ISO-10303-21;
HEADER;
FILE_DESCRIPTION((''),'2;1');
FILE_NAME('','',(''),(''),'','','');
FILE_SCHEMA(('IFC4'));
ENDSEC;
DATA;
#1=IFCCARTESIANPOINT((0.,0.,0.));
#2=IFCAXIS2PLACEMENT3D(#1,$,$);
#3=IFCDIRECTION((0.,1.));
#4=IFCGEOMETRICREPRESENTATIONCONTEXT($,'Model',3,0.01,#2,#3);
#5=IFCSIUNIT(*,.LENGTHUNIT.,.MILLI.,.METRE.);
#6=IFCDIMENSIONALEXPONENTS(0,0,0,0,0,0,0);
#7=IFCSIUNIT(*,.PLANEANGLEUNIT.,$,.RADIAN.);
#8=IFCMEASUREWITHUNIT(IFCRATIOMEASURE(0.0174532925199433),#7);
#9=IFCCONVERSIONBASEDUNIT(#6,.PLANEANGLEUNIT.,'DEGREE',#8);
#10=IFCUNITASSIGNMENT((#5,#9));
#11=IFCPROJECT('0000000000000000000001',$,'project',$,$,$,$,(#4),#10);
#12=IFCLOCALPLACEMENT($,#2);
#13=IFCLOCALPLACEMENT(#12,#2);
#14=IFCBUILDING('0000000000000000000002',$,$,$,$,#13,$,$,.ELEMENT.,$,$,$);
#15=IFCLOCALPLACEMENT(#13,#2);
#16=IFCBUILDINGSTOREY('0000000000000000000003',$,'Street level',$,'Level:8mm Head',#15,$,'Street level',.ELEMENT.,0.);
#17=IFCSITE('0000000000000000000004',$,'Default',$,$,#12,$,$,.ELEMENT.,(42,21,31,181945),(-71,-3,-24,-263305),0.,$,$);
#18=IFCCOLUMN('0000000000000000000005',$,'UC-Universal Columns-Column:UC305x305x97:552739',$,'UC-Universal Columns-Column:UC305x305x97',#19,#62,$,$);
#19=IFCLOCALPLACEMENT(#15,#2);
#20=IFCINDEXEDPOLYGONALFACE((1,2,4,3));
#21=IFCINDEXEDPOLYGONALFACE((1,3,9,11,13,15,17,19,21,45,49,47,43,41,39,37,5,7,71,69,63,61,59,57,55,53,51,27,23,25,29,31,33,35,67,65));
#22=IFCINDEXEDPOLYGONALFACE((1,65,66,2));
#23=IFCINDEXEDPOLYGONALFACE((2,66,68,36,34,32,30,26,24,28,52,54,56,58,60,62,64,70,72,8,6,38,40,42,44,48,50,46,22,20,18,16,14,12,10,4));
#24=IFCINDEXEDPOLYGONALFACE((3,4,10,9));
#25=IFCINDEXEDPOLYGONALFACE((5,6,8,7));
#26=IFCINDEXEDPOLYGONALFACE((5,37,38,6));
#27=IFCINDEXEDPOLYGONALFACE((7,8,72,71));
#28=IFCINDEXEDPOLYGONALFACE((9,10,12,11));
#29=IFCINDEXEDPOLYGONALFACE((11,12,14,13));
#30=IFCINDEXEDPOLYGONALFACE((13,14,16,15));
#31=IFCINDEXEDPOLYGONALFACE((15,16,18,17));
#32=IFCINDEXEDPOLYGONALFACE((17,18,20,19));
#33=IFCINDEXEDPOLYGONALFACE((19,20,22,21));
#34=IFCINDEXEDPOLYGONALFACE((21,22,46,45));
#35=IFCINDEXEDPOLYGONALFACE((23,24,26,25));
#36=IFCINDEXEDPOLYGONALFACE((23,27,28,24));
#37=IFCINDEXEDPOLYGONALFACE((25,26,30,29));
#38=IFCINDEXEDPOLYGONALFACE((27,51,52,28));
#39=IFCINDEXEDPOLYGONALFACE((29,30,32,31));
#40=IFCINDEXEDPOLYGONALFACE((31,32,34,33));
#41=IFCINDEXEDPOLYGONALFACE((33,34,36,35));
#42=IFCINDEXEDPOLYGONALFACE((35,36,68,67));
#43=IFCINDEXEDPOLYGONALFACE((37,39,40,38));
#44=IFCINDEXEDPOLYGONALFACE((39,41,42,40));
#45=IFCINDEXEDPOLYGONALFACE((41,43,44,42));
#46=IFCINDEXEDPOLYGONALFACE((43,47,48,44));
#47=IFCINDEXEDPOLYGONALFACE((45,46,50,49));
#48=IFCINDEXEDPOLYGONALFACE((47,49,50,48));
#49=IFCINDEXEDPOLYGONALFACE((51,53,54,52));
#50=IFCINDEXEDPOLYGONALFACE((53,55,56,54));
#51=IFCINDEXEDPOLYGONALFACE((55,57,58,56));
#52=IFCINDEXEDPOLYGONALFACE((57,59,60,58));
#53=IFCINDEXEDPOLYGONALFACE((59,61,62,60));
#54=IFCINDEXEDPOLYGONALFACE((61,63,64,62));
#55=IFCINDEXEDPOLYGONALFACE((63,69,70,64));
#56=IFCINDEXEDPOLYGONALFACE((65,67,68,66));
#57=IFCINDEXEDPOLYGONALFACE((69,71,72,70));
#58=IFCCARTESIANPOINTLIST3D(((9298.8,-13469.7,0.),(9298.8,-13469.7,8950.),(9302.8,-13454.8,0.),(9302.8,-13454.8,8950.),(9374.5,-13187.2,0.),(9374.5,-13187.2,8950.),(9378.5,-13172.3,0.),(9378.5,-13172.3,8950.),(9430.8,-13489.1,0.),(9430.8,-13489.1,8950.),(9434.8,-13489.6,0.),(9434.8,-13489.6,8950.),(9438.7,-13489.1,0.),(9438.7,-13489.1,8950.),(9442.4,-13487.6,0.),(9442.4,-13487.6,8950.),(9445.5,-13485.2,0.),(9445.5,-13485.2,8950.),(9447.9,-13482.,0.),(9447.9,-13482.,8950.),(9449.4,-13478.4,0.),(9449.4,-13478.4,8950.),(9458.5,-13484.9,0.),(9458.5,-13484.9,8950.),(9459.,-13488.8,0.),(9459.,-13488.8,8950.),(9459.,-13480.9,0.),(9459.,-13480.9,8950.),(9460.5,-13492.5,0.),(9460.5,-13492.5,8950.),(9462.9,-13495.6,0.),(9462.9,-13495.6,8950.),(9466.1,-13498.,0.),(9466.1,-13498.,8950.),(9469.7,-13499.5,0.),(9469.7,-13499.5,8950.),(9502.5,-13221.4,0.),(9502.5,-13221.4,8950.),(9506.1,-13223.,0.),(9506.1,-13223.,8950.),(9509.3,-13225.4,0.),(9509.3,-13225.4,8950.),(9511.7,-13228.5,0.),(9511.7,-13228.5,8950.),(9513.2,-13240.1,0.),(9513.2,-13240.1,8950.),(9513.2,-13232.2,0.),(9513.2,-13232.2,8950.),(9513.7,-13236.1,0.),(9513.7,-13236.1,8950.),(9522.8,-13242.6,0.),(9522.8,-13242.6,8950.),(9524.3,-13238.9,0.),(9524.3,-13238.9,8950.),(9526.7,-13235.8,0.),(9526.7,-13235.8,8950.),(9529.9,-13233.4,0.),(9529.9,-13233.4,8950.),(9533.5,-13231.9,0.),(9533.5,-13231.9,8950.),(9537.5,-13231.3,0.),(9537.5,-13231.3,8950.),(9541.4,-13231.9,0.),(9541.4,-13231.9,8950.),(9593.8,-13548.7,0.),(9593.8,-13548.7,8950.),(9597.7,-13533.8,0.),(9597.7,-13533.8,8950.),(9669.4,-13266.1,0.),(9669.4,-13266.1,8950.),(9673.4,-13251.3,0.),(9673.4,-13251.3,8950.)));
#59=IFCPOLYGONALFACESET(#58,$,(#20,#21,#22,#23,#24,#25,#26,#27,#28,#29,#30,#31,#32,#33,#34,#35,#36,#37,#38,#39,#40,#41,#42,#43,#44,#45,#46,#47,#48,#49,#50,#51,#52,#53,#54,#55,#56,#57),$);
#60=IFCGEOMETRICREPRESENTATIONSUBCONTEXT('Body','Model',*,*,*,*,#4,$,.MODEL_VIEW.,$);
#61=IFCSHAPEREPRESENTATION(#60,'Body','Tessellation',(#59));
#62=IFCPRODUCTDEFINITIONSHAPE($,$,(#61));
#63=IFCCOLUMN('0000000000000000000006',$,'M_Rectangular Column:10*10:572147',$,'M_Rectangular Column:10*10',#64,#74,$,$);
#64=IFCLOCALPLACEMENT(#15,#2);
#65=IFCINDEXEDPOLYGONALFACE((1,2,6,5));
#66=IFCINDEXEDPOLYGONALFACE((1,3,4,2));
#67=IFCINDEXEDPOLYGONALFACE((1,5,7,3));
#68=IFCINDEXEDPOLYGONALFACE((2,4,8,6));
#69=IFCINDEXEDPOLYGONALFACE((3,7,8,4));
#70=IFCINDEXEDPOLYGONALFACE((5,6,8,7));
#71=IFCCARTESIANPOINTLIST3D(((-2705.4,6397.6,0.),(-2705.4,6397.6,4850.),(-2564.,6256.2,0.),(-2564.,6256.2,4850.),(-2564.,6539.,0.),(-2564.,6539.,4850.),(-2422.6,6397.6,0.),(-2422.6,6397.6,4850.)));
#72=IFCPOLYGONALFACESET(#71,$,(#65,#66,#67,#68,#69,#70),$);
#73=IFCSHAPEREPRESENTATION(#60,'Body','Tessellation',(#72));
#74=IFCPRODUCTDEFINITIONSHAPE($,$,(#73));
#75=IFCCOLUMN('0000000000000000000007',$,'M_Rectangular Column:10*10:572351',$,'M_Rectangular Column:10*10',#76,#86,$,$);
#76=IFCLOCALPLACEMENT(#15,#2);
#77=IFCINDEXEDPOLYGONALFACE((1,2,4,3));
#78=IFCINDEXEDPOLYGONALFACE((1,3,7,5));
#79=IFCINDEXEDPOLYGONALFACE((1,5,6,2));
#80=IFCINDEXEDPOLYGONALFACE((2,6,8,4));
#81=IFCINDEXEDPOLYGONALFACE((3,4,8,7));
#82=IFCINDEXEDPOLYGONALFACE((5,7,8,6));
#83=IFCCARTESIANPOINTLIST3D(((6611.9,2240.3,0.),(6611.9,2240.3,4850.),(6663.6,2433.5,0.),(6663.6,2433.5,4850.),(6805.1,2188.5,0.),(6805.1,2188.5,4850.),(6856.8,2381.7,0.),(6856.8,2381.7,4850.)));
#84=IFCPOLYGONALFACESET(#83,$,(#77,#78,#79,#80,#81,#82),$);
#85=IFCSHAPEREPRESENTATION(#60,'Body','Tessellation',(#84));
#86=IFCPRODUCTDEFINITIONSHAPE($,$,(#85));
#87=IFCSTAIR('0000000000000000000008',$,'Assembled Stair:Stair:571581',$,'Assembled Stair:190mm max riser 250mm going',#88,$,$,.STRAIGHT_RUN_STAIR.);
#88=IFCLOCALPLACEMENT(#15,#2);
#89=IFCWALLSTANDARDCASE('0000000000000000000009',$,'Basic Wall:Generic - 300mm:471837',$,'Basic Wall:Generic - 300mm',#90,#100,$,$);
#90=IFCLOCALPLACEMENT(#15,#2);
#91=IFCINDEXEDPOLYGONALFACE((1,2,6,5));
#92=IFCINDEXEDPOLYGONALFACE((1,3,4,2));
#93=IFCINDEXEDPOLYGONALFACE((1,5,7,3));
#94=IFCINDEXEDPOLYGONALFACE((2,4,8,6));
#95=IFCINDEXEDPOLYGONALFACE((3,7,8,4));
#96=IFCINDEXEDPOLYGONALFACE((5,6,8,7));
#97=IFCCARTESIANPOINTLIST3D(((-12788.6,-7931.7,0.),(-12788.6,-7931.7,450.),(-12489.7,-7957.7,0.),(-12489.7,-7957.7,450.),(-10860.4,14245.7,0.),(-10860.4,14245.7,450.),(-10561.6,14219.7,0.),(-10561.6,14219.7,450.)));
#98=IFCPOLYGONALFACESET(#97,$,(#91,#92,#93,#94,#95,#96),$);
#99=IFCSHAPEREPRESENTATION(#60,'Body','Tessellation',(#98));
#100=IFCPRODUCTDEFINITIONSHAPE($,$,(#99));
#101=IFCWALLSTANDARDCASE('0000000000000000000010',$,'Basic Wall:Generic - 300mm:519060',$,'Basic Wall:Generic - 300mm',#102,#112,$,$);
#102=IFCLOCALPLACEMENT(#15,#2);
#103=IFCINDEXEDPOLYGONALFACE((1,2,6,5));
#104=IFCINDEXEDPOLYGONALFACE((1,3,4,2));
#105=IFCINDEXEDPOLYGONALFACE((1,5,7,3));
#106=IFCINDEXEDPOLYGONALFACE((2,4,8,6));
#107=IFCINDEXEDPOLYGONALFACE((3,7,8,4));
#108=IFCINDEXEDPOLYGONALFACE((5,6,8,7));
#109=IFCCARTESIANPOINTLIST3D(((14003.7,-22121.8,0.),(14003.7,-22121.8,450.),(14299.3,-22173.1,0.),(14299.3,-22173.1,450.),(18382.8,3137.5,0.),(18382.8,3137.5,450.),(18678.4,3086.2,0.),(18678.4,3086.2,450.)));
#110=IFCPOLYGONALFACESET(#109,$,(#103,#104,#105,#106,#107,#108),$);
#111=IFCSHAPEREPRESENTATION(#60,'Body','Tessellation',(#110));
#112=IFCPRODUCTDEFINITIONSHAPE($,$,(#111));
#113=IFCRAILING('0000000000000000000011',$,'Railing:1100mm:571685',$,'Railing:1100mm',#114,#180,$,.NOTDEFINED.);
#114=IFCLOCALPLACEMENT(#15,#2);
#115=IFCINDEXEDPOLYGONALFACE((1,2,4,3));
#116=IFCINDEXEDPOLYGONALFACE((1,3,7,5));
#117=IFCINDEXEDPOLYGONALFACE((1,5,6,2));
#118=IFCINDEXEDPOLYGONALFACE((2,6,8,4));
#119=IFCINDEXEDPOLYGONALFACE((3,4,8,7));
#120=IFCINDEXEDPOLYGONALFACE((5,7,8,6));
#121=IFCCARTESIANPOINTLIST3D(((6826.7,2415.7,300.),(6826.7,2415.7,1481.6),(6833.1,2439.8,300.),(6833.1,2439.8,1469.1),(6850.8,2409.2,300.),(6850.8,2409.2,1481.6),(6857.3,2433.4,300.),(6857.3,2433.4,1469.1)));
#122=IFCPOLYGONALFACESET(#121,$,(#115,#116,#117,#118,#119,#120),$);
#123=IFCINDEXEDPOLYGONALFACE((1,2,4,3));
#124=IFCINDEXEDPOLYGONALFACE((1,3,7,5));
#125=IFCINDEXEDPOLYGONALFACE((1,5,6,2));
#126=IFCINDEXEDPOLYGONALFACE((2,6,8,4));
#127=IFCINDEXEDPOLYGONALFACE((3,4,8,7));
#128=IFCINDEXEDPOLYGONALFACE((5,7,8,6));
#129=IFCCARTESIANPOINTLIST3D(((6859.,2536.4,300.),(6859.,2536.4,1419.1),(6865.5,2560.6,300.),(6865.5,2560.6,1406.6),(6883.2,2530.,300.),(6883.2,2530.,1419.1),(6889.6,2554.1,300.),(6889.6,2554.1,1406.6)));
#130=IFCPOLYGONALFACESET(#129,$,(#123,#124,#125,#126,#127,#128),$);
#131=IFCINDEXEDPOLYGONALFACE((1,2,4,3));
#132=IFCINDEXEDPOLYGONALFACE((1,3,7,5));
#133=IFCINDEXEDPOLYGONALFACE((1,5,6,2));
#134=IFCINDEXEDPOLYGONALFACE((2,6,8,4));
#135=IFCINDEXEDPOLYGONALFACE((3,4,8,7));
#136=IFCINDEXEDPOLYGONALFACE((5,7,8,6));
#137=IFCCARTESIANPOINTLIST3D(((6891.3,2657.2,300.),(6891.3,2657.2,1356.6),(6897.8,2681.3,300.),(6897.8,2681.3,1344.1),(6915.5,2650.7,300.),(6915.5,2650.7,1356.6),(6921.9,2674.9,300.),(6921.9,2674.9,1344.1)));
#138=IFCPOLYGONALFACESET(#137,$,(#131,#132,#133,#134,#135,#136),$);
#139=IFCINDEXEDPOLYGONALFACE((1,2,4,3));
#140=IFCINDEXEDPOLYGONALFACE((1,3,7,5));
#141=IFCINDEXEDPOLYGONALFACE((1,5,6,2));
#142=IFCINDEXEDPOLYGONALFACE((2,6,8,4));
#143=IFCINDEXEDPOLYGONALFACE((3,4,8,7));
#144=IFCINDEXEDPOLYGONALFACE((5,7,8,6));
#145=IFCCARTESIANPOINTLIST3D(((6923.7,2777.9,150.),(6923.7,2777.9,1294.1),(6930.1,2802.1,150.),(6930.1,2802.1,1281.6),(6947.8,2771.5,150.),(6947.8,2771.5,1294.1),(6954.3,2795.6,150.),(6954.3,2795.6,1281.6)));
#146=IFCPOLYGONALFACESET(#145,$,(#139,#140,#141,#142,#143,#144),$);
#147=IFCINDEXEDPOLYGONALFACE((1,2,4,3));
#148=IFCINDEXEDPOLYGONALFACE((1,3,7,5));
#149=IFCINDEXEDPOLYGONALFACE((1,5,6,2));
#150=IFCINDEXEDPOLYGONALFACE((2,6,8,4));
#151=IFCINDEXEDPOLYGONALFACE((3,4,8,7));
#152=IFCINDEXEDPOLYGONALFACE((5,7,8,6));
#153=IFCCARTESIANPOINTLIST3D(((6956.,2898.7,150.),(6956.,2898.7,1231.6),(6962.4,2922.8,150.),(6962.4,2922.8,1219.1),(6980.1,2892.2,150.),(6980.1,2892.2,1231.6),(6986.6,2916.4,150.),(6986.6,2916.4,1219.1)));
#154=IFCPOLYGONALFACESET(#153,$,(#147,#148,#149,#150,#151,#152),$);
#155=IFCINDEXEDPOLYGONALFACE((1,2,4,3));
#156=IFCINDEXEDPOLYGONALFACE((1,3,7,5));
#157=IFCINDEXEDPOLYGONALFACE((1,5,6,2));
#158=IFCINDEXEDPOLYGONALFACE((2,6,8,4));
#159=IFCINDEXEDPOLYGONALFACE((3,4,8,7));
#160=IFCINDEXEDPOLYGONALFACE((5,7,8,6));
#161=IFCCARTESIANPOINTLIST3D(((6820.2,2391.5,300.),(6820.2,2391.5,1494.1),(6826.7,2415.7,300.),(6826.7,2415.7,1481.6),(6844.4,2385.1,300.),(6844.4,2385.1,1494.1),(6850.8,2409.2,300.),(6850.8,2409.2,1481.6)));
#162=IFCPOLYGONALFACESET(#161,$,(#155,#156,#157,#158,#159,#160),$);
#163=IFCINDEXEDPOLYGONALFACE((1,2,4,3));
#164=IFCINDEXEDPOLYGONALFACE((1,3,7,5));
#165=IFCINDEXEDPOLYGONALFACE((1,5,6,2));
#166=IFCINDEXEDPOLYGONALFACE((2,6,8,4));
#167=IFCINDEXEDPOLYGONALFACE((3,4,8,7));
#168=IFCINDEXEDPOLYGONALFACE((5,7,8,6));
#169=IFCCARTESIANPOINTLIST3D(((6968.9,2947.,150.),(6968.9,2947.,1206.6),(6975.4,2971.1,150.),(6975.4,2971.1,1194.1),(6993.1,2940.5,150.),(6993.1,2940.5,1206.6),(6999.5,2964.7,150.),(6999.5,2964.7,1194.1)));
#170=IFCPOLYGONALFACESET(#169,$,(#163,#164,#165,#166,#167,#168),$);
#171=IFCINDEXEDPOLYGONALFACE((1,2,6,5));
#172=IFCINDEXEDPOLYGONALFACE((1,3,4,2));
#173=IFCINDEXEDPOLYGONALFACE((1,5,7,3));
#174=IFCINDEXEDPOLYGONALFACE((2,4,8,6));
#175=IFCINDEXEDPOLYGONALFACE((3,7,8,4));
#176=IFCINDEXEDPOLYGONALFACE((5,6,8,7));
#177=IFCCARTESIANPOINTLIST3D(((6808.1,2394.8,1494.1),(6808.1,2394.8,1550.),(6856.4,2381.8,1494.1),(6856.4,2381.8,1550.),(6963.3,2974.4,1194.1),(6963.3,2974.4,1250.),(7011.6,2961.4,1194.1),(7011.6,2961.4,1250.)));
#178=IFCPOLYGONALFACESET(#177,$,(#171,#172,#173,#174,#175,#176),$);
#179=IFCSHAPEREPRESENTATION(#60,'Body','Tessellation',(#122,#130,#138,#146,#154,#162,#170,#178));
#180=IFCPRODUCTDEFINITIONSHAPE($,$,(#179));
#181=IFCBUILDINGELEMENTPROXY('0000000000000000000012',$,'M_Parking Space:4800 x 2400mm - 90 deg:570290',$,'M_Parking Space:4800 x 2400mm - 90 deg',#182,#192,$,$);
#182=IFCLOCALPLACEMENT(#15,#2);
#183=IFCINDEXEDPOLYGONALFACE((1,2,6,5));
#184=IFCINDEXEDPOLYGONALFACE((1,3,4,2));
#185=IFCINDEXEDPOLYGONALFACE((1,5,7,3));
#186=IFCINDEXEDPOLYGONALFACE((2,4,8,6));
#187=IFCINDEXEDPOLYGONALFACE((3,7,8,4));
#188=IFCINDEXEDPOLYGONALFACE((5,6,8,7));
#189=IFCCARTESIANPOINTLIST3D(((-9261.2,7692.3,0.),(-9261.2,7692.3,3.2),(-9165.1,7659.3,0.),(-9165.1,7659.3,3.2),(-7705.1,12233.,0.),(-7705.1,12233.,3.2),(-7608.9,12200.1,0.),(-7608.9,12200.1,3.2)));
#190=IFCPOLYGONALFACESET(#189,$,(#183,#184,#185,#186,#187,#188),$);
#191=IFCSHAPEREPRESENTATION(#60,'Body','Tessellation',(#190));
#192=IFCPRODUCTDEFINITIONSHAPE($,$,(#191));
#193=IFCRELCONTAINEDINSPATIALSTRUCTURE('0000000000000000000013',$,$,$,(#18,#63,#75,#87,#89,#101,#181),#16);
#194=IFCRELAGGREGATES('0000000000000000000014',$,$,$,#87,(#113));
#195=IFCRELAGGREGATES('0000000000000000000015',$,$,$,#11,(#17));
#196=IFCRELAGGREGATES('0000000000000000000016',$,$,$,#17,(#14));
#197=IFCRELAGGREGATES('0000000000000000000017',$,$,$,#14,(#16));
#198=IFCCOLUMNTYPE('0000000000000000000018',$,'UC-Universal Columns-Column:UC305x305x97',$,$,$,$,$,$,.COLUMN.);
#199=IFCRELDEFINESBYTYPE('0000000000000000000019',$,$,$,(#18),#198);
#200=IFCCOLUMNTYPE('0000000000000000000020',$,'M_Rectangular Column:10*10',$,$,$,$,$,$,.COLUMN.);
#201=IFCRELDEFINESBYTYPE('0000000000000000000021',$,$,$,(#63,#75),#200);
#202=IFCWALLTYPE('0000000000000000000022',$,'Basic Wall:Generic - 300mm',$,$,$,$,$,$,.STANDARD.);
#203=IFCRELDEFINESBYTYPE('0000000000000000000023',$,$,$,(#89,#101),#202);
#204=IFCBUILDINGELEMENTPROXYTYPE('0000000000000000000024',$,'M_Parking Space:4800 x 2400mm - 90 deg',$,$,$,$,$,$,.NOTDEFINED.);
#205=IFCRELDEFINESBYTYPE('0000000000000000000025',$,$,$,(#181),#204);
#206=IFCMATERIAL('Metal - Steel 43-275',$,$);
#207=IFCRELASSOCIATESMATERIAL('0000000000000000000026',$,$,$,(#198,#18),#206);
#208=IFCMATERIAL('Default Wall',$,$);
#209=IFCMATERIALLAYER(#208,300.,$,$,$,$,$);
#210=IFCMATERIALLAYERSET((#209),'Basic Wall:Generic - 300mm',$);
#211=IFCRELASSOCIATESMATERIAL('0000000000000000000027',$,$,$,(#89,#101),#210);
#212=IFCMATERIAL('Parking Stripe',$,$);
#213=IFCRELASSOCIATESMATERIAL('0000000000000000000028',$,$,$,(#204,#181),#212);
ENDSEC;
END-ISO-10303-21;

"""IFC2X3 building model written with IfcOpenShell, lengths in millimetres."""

from ifc_helpers import new_model, entity, si_unit, converted_unit, direction, frame, frame_2d, origin, origin_2d_with_axis, place, context, subcontext, project, spatial, polyline, rectangle, i_section, outline, extrude, source, transform, mapped, material, layer, layer_set, layer_usage, type_object, type_shapes, element, aggregate, save


model = new_model("IFC2X3")

# Units and contexts
model_context = context("Model", 3, precision=0.01, world=origin(), true_north=direction((0.0, 1.0)))
body_context = subcontext(model_context, "Body", "Model", "MODEL_VIEW")
ifc_project = project(units=[si_unit("LENGTHUNIT", "METRE", prefix="MILLI"), converted_unit("PLANEANGLEUNIT", "DEGREE", entity("IfcRatioMeasure", 0.0174532925199433), si_unit("PLANEANGLEUNIT", "RADIAN"), dimensions=[0, 0, 0, 0, 0, 0, 0])], contexts=[model_context])

# Site, building, storey
site_placement = place(None, origin())
site = spatial("IfcSite", under=ifc_project, at=site_placement, Name="Default", CompositionType="ELEMENT", RefLatitude=(42, 21, 31, 181945), RefLongitude=(-71, -3, -24, -263305), RefElevation=0.0)
building_placement = place(site_placement, origin())
building = spatial("IfcBuilding", under=site, at=building_placement, CompositionType="ELEMENT")
storey_placement = place(building_placement, origin())
storey = spatial("IfcBuildingStorey", under=building, at=storey_placement, Name="Street level", ObjectType="Level:8mm Head", LongName="Street level", CompositionType="ELEMENT", Elevation=0.0)

# Columns
ifc_material_1 = material(Name="Metal - Steel 43-275")
column_type_1 = type_object("IfcColumnType", Name="UC-Universal Columns-Column:UC305x305x97", PredefinedType="COLUMN", material=ifc_material_1)
shared_shape_1 = source(origin(), body_context, "Body", "SweptSolid", [
    extrude(i_section(OverallWidth=305.3, OverallDepth=307.9, WebThickness=9.9, FlangeThickness=15.4, FilletRadius=15.2, at=frame_2d((0.0, 0.0), x_axis=(0.0, 1.0))), frame((0.0, 0.0, 0.0), z_axis=(0.0, 0.0, 1.0), x_axis=(0.0, -1.0, 0.0)), (0.0, 0.0, 1.0), 8950.0),
])
type_shapes(column_type_1, [shared_shape_1])
column_placement = place(storey_placement, frame((9486.1, -13360.5, 0.0), z_axis=(0.0, 0.0, 1.0), x_axis=(0.965983, -0.258607, 0.0)))
element("IfcColumn", 1, at=column_placement, inside=storey, type_object=column_type_1, material=ifc_material_1, Name="UC-Universal Columns-Column:UC305x305x97:552739", ObjectType="UC-Universal Columns-Column:UC305x305x97", context=body_context, shape_type="MappedRepresentation", body=[
    mapped(shared_shape_1, transform((0.0, 0.0, 0.0), scale=1.0)),
])
column_type_2 = type_object("IfcColumnType", Name="M_Rectangular Column:10*10", PredefinedType="COLUMN")
shared_shape_2 = source(origin(), body_context, "Body", "SweptSolid", [
    extrude(rectangle(XDim=200.0, YDim=200.0, at=origin_2d_with_axis()), frame((0.0, 0.0, 0.0), z_axis=(0.0, 0.0, 1.0), x_axis=(0.0, -1.0, 0.0)), (0.0, 0.0, 1.0), 4850.0),
])
type_shapes(column_type_2, [shared_shape_2])
for number, where, z_axis, x_axis, name in (
    (2, (-2564.0, 6397.6, 0.0), (0.0, 0.0, 1.0), (0.707107, 0.707107, 0.0), "M_Rectangular Column:10*10:572147"),
    (3, (6734.4, 2311.0, 0.0), (0.0, 0.0, 1.0), (0.258607, 0.965983, 0.0), "M_Rectangular Column:10*10:572351"),
):
    element("IfcColumn", number, at=place(storey_placement, frame(where, z_axis=z_axis, x_axis=x_axis)), inside=storey, type_object=column_type_2, Name=name, ObjectType="M_Rectangular Column:10*10", context=body_context, shape_type="MappedRepresentation", body=[
        mapped(shared_shape_2, transform((0.0, 0.0, 0.0), scale=1.0)),
    ])

# Stair
stair_placement = place(storey_placement, origin())
stair = element("IfcStair", 4, at=stair_placement, inside=storey, Name="Assembled Stair:Stair:571581", ObjectType="Assembled Stair:190mm max riser 250mm going", ShapeType="STRAIGHT_RUN_STAIR")

# Walls
ifc_material_2 = material(Name="Default Wall")
ifc_layer_1 = layer(ifc_material_2, 300.0)
ifc_layer_set_1 = layer_set([ifc_layer_1], Name="Basic Wall:Generic - 300mm")
ifc_layer_usage_1 = layer_usage(ifc_layer_set_1, "AXIS2", "NEGATIVE", 150.0)
wall_type = type_object("IfcWallType", Name="Basic Wall:Generic - 300mm", PredefinedType="STANDARD")
wall_1_placement = place(storey_placement, frame((-10711.0, 14232.7, 0.0), z_axis=(0.0, 0.0, 1.0), x_axis=(-0.086615, -0.996242, 0.0)))
element("IfcWallStandardCase", 5, at=wall_1_placement, inside=storey, type_object=wall_type, material=ifc_layer_usage_1, Name="Basic Wall:Generic - 300mm:471837", ObjectType="Basic Wall:Generic - 300mm", context=body_context, shape_type="SweptSolid", body=[
    extrude(rectangle(XDim=22261.1, YDim=300.0, at=frame_2d((11130.5, 0.0), x_axis=(-1.0, 0.0))), origin(), (0.0, 0.0, 1.0), 450.0),
])
ifc_layer_usage_2 = layer_usage(ifc_layer_set_1, "AXIS2", "NEGATIVE", 150.0)
wall_2_placement = place(storey_placement, frame((14151.5, -22147.4, 0.0), z_axis=(0.0, 0.0, 1.0), x_axis=(0.17082, 0.985302, 0.0)))
element("IfcWallStandardCase", 6, at=wall_2_placement, inside=storey, type_object=wall_type, material=ifc_layer_usage_2, Name="Basic Wall:Generic - 300mm:519060", ObjectType="Basic Wall:Generic - 300mm", context=body_context, shape_type="SweptSolid", body=[
    extrude(rectangle(XDim=25636.1, YDim=300.0, at=frame_2d((12818.0, 0.0), x_axis=(-1.0, 0.0))), origin(), (0.0, 0.0, 1.0), 450.0),
])

# Railing
railing_placement = place(stair_placement, origin())
railing = element("IfcRailing", 7, at=railing_placement, Name="Railing:1100mm:571685", ObjectType="Railing:1100mm", PredefinedType="NOTDEFINED", context=body_context, shape_type="SweptSolid", body=[
    extrude(outline(polyline([(-587.7, -12.5), (581.4, -12.5), (593.9, 12.5), (-587.7, 12.5), (-587.7, -12.5)])), frame((6829.9, 2427.8, 887.7), z_axis=(0.965983, -0.258606, 0.0), x_axis=(0.0, 0.0, 1.0)), (0.0, 0.0, 1.0), 25.0),
    extrude(outline(polyline([(-556.4, -12.5), (550.2, -12.5), (562.7, 12.5), (-556.4, 12.5), (-556.4, -12.5)])), frame((6862.2, 2548.5, 856.4), z_axis=(0.965983, -0.258606, 0.0), x_axis=(0.0, 0.0, 1.0)), (0.0, 0.0, 1.0), 25.0),
    extrude(outline(polyline([(-525.2, -12.5), (518.9, -12.5), (531.4, 12.5), (-525.2, 12.5), (-525.2, -12.5)])), frame((6894.6, 2669.3, 825.2), z_axis=(0.965983, -0.258606, 0.0), x_axis=(0.0, 0.0, 1.0)), (0.0, 0.0, 1.0), 25.0),
    extrude(outline(polyline([(-568.9, -12.5), (562.7, -12.5), (575.2, 12.5), (-568.9, 12.5), (-568.9, -12.5)])), frame((6926.9, 2790.0, 718.9), z_axis=(0.965983, -0.258606, 0.0), x_axis=(0.0, 0.0, 1.0)), (0.0, 0.0, 1.0), 25.0),
    extrude(outline(polyline([(-537.7, -12.5), (531.4, -12.5), (543.9, 12.5), (-537.7, 12.5), (-537.7, -12.5)])), frame((6959.2, 2910.8, 687.7), z_axis=(0.965983, -0.258606, 0.0), x_axis=(0.0, 0.0, 1.0)), (0.0, 0.0, 1.0), 25.0),
    extrude(outline(polyline([(-593.9, -12.5), (587.7, -12.5), (600.2, 12.5), (-593.9, 12.5), (-593.9, -12.5)])), frame((6823.4, 2403.6, 893.9), z_axis=(0.965983, -0.258606, 0.0), x_axis=(0.0, 0.0, 1.0)), (0.0, 0.0, 1.0), 25.0),
    extrude(outline(polyline([(-525.2, -12.5), (518.9, -12.5), (531.4, 12.5), (-525.2, 12.5), (-525.2, -12.5)])), frame((6972.1, 2959.1, 675.2), z_axis=(0.965983, -0.258606, 0.0), x_axis=(0.0, 0.0, 1.0)), (0.0, 0.0, 1.0), 25.0),
    extrude(outline(polyline([(-322.9, -25.0), (347.9, -25.0), (322.9, 25.0), (-347.9, 25.0), (-322.9, -25.0)])), frame((6885.7, 2684.6, 1372.0), z_axis=(0.965983, -0.258606, 0.0), x_axis=(-0.231304, -0.864001, 0.447214)), (0.0, 0.0, 1.0), 50.0),
])
aggregate(stair, [railing])

# Building element proxy
ifc_material_3 = material(Name="Parking Stripe")
building_element_proxy_type = type_object("IfcBuildingElementProxyType", Name="M_Parking Space:4800 x 2400mm - 90 deg", PredefinedType="NOTDEFINED", material=ifc_material_3)
shared_shape_3 = source(origin(), body_context, "Body", "SweptSolid", [
    extrude(rectangle(XDim=101.6, YDim=4800.0, at=origin_2d_with_axis()), frame((0.0, 2400.0, 0.0)), (0.0, 0.0, 1.0), 3.2),
])
type_shapes(building_element_proxy_type, [shared_shape_3])
for number, where, z_axis, x_axis, name in (
    (8, (-9213.1, 7675.8, 0.0), (0.0, 0.0, 1.0), (0.945989, -0.324198, 0.0), "M_Parking Space:4800 x 2400mm - 90 deg:570290"),
):
    element("IfcBuildingElementProxy", number, at=place(storey_placement, frame(where, z_axis=z_axis, x_axis=x_axis)), inside=storey, type_object=building_element_proxy_type, material=ifc_material_3, Name=name, ObjectType="M_Parking Space:4800 x 2400mm - 90 deg", context=body_context, shape_type="MappedRepresentation", body=[
        mapped(shared_shape_3, transform((0.0, 0.0, 0.0), scale=1.0)),
    ])

save(model, "model.ifc")
